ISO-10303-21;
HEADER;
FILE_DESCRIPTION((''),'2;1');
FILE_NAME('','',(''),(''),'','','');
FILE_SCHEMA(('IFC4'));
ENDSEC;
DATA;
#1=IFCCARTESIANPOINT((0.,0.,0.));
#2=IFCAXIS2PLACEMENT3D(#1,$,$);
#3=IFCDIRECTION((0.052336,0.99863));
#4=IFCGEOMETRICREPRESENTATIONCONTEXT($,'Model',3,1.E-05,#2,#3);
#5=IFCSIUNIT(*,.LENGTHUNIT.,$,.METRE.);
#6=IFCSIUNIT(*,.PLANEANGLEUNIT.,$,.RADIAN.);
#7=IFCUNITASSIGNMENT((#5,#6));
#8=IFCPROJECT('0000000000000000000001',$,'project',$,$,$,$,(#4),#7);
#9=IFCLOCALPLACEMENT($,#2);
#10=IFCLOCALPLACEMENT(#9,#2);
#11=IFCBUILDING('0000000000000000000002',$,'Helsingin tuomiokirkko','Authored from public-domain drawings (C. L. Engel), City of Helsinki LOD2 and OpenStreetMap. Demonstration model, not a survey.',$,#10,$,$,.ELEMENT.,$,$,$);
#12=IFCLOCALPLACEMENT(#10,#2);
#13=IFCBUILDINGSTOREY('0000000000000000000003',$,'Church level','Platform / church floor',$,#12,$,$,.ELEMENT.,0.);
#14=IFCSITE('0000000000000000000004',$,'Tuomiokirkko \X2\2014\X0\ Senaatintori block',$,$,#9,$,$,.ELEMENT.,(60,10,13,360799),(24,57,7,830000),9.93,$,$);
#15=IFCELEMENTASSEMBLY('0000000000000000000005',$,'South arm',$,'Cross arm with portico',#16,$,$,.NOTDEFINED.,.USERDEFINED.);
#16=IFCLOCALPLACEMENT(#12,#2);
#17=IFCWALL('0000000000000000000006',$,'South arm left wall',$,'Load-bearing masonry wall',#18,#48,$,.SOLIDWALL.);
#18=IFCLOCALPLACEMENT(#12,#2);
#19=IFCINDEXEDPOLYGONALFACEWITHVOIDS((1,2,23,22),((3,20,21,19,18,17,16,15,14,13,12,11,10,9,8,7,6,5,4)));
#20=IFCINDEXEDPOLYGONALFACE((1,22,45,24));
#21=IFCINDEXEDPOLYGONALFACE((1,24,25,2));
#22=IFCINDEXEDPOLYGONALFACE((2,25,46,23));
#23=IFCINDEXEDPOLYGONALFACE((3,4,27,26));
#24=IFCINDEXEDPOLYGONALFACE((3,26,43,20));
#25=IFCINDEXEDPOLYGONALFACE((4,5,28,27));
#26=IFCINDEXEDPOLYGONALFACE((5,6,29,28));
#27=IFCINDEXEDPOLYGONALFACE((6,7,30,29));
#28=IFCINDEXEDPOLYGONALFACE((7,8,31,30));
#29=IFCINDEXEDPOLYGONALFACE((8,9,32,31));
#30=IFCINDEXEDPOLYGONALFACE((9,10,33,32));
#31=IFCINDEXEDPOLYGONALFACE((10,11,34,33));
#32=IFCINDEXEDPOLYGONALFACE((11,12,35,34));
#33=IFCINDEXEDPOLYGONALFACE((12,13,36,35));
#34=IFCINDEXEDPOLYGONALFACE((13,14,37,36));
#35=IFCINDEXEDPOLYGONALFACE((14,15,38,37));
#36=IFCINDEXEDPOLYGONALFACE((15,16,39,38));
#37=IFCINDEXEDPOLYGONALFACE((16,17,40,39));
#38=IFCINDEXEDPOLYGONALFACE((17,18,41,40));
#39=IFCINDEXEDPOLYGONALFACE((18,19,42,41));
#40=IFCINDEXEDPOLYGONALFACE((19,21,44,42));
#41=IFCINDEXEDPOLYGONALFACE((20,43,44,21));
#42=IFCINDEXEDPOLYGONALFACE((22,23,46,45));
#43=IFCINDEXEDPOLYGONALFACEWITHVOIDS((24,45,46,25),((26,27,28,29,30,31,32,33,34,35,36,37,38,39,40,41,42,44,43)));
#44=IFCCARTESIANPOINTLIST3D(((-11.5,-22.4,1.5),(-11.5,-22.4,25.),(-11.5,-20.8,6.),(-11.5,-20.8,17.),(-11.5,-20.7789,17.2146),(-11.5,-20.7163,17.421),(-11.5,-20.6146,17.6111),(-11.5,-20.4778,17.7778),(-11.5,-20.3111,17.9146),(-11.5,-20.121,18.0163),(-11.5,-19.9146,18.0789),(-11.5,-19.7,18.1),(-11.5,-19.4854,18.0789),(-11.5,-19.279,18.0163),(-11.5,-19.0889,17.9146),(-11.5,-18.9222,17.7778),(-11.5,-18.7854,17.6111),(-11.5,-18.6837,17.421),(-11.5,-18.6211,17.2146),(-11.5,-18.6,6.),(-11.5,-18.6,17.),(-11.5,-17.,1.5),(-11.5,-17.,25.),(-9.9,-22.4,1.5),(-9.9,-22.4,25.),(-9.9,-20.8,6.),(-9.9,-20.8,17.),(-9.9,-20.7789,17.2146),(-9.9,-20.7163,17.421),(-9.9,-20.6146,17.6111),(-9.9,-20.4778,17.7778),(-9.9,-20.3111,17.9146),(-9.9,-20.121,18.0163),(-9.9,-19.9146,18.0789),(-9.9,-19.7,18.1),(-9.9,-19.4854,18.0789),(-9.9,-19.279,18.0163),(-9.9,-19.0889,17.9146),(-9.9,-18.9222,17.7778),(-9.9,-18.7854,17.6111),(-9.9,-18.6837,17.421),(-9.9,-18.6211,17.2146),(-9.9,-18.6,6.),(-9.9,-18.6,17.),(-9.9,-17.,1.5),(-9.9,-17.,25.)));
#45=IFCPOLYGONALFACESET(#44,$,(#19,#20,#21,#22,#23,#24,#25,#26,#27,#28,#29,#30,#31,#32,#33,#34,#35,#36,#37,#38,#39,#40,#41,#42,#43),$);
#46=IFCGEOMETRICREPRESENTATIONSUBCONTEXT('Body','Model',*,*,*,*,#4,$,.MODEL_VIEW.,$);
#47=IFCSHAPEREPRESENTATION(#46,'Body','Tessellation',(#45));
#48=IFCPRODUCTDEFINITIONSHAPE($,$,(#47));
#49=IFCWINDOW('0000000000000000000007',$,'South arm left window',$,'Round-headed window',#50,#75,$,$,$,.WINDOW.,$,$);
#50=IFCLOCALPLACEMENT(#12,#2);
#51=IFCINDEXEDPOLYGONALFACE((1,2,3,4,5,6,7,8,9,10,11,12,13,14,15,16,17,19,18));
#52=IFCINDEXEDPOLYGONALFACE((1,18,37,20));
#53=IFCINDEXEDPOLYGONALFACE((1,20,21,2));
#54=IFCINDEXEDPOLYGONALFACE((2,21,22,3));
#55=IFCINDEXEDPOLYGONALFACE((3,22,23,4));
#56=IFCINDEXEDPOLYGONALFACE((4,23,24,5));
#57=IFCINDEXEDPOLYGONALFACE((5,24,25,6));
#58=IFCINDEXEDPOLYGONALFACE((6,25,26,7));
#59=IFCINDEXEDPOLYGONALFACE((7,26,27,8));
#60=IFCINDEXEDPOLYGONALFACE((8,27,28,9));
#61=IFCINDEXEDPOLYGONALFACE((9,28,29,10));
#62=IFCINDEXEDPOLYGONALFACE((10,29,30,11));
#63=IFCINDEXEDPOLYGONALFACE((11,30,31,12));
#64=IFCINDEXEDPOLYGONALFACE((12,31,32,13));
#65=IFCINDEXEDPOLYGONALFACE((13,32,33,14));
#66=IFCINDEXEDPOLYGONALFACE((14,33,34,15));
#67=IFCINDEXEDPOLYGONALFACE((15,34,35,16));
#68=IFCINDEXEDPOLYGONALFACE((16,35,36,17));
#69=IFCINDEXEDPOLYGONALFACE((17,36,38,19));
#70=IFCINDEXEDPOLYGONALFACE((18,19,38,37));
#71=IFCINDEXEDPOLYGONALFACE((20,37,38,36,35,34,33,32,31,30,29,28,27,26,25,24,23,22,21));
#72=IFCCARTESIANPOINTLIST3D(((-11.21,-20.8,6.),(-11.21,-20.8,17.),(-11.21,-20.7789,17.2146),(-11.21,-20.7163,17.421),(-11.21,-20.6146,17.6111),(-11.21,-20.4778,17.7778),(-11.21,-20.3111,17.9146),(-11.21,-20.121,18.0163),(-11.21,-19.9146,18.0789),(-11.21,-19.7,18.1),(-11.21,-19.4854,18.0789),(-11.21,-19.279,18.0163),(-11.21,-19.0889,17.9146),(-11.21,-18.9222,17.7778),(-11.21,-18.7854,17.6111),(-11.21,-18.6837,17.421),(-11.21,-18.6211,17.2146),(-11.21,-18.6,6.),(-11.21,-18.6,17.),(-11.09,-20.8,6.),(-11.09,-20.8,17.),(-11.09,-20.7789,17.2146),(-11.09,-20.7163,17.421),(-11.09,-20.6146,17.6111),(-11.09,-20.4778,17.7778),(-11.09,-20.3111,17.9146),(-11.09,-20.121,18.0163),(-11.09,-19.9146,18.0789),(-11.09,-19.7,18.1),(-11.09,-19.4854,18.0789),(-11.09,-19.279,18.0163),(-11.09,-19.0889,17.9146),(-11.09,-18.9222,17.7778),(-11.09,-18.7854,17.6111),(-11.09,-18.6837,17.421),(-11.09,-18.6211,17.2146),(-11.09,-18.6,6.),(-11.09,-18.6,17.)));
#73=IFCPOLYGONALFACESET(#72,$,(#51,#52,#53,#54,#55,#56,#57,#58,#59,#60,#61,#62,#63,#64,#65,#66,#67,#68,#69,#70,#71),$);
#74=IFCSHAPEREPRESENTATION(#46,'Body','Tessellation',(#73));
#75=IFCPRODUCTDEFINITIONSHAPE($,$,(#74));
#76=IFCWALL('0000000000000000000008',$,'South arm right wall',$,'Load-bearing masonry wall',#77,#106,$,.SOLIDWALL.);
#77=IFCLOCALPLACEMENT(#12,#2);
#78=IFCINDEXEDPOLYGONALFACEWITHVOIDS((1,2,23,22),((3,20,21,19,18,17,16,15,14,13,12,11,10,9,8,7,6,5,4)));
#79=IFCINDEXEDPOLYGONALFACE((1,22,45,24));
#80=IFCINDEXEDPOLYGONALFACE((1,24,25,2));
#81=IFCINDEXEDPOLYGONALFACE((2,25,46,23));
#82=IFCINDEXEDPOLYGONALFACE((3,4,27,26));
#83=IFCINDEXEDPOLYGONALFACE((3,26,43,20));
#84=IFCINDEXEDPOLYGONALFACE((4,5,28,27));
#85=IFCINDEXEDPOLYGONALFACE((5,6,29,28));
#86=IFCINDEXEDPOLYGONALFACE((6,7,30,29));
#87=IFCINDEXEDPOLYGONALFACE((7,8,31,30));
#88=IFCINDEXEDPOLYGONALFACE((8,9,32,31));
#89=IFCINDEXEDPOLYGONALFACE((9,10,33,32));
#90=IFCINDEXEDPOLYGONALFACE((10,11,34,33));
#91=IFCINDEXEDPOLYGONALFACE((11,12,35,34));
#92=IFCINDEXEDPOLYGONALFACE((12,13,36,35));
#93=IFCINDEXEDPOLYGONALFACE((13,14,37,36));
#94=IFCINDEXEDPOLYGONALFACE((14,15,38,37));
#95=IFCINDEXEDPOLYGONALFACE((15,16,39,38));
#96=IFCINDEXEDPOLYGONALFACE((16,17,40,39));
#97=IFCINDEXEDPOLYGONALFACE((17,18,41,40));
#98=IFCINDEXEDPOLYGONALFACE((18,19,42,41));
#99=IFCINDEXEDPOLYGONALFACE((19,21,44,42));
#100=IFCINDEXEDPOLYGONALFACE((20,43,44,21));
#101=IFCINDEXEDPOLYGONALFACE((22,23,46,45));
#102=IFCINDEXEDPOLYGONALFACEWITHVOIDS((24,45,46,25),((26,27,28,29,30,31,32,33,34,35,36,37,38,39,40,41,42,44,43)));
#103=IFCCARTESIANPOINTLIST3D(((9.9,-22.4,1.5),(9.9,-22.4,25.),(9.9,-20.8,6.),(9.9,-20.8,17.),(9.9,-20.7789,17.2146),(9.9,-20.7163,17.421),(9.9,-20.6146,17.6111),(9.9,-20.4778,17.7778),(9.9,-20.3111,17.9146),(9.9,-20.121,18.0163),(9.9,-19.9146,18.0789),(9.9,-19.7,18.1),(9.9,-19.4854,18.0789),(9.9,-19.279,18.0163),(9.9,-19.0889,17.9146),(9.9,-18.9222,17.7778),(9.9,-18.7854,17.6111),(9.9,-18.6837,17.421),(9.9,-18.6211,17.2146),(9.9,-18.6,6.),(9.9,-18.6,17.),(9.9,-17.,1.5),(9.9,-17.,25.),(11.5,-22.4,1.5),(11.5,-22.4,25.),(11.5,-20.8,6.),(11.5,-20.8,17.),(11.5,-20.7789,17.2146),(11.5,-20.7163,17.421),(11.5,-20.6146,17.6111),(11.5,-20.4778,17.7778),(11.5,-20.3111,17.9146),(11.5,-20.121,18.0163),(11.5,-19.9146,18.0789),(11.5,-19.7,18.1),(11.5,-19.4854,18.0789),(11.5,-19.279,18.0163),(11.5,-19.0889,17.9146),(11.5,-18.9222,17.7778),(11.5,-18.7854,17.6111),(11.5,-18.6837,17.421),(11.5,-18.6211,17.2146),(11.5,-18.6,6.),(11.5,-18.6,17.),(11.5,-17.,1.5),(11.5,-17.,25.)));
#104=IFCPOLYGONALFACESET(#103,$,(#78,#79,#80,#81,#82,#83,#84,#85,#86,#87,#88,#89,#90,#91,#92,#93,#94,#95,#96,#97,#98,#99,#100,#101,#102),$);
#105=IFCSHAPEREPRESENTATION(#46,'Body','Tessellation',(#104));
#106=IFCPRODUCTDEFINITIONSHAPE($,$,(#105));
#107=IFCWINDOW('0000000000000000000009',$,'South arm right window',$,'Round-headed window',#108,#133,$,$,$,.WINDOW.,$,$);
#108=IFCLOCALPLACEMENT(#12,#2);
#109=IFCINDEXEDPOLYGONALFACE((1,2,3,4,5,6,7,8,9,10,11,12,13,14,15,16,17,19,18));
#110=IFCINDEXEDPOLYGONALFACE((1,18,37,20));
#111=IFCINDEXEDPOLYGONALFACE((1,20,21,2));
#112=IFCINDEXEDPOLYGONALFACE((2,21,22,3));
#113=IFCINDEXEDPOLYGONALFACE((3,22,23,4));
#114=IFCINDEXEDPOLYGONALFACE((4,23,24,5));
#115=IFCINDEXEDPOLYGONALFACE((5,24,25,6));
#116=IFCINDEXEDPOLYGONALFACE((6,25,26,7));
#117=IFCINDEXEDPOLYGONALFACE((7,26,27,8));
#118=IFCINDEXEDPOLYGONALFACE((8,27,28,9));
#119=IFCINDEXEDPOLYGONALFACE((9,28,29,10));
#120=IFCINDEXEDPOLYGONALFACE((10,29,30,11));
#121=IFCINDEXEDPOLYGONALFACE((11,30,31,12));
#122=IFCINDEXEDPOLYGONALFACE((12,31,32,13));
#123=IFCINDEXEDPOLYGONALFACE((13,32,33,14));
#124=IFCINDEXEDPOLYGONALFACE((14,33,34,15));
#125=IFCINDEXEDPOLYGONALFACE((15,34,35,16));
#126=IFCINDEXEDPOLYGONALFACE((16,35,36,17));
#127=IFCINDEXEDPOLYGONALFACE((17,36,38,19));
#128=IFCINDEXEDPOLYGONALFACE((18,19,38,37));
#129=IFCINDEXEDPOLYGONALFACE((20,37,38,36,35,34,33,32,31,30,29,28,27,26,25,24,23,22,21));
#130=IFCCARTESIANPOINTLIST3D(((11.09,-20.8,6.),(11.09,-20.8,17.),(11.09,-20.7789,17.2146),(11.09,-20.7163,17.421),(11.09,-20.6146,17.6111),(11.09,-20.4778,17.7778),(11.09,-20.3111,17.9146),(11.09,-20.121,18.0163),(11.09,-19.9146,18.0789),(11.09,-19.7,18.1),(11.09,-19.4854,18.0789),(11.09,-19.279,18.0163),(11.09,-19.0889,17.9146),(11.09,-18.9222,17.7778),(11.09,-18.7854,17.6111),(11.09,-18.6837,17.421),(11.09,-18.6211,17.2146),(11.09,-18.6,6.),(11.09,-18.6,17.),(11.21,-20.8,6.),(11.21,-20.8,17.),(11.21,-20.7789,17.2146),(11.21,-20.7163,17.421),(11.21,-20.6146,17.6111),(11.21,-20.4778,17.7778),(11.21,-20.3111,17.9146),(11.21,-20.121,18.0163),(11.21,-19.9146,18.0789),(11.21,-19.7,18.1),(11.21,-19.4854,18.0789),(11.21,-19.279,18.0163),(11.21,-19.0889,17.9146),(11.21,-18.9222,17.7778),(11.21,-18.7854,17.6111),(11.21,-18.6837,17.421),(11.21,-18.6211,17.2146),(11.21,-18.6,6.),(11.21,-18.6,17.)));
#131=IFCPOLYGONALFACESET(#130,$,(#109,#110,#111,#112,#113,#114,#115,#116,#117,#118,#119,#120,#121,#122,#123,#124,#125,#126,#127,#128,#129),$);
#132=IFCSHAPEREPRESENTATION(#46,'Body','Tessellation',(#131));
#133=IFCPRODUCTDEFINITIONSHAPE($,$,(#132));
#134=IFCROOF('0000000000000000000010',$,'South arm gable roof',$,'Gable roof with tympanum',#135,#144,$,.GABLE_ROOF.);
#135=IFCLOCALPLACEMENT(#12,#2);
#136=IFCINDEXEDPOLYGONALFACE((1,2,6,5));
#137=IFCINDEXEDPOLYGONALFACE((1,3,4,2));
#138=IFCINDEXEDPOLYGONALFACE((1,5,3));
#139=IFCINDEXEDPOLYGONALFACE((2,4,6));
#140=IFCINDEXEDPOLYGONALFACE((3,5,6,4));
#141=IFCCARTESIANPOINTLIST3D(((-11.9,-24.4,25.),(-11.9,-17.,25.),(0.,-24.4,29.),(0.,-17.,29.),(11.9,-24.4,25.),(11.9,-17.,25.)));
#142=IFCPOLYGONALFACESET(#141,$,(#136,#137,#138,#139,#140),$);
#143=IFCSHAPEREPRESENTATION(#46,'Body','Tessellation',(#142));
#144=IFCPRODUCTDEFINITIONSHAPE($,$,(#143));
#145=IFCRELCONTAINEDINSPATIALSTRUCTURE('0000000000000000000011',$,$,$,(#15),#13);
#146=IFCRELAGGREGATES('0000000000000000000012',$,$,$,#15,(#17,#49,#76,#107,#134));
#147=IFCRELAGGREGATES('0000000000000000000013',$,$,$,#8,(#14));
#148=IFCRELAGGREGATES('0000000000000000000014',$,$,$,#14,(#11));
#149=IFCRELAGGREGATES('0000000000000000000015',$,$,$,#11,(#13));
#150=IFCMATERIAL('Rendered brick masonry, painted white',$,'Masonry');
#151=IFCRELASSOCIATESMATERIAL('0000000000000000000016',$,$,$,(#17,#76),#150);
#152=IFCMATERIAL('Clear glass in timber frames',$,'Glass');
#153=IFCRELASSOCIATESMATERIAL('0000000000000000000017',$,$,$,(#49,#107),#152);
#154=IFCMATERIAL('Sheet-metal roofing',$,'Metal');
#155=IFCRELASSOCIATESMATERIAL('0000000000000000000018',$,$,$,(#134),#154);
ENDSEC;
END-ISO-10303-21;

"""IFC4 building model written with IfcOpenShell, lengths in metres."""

from ifc_helpers import new_model, si_unit, direction, frame, frame_2d, origin, place, context, subcontext, project, spatial, polyline, rectangle, outline, extrude, material, element, fill, aggregate, save


model = new_model("IFC4")

# Units and contexts
model_context = context("Model", 3, precision=1e-05, world=origin(), true_north=direction((0.052336, 0.99863)))
body_context = subcontext(model_context, "Body", "Model", "MODEL_VIEW")
ifc_project = project(units=[si_unit("LENGTHUNIT", "METRE"), si_unit("PLANEANGLEUNIT", "RADIAN")], contexts=[model_context])

# Site, building, storey
site_placement = place(None, origin())
site = spatial("IfcSite", under=ifc_project, at=site_placement, Name="Tuomiokirkko — Senaatintori block", CompositionType="ELEMENT", RefLatitude=(60, 10, 13, 360799), RefLongitude=(24, 57, 7, 830000), RefElevation=9.93)
building_placement = place(site_placement, origin())
building = spatial("IfcBuilding", under=site, at=building_placement, Name="Helsingin tuomiokirkko", Description="Authored from public-domain drawings (C. L. Engel), City of Helsinki LOD2 and OpenStreetMap. Demonstration model, not a survey.", CompositionType="ELEMENT")
storey_placement = place(building_placement, origin())
storey = spatial("IfcBuildingStorey", under=building, at=storey_placement, Name="Church level", Description="Platform / church floor", CompositionType="ELEMENT", Elevation=0.0)

# Element assembly, walls, openings, windows, roof
assembly_1_placement = place(building_placement, origin())
assembly_1 = element("IfcElementAssembly", 1, at=assembly_1_placement, inside=storey, Name="South arm", ObjectType="Cross arm with portico", AssemblyPlace="NOTDEFINED", PredefinedType="USERDEFINED")
ifc_material_1 = material(Name="Rendered brick masonry, painted white", Category="Masonry")
ifc_material_2 = material(Name="Clear glass in timber frames", Category="Glass")
wall_1_placement = place(building_placement, origin())
wall_1 = element("IfcWall", 2, at=wall_1_placement, material=ifc_material_1, Name="South arm left wall", ObjectType="Load-bearing masonry wall", PredefinedType="SOLIDWALL", context=body_context, shape_type="SweptSolid", body=[
    extrude(rectangle(XDim=5.4, YDim=1.6, at=frame_2d((0.0, 0.0), x_axis=(0.0, -1.0))), frame((-10.7, -19.7, 1.5)), (0.0, 0.0, 1.0), 23.5),
])
opening_1_placement = place(building_placement, origin())
opening_1 = element("IfcOpeningElement", 3, at=opening_1_placement, cuts=wall_1, PredefinedType="OPENING", context=body_context, shape_type="SweptSolid", body=[
    extrude(outline(polyline([(-1.1, 0.0), (1.1, 0.0), (1.1, 11.0), (1.0789, 11.2146), (1.0163, 11.421), (0.9146, 11.6111), (0.7778, 11.7778), (0.6111, 11.9146), (0.421, 12.0163), (0.2146, 12.0789), (0.0, 12.1), (-0.2146, 12.0789), (-0.421, 12.0163), (-0.6111, 11.9146), (-0.7778, 11.7778), (-0.9146, 11.6111), (-1.0163, 11.421), (-1.0789, 11.2146), (-1.1, 11.0), (-1.1, 0.0)])), frame((-9.7, -19.7, 6.0), z_axis=(-1.0, 0.0, 0.0), x_axis=(0.0, -1.0, 0.0)), (0.0, 0.0, 1.0), 2.0),
])
window_1_placement = place(building_placement, origin())
window_1 = element("IfcWindow", 4, at=window_1_placement, material=ifc_material_2, Name="South arm left window", ObjectType="Round-headed window", PredefinedType="WINDOW", context=body_context, shape_type="SweptSolid", body=[
    extrude(outline(polyline([(-1.1, 0.0), (1.1, 0.0), (1.1, 11.0), (1.0789, 11.2146), (1.0163, 11.421), (0.9146, 11.6111), (0.7778, 11.7778), (0.6111, 11.9146), (0.421, 12.0163), (0.2146, 12.0789), (0.0, 12.1), (-0.2146, 12.0789), (-0.421, 12.0163), (-0.6111, 11.9146), (-0.7778, 11.7778), (-0.9146, 11.6111), (-1.0163, 11.421), (-1.0789, 11.2146), (-1.1, 11.0), (-1.1, 0.0)])), frame((-11.09, -19.7, 6.0), z_axis=(-1.0, 0.0, 0.0), x_axis=(0.0, -1.0, 0.0)), (0.0, 0.0, 1.0), 0.12),
])
fill(opening_1, window_1)
wall_2_placement = place(building_placement, origin())
wall_2 = element("IfcWall", 5, at=wall_2_placement, material=ifc_material_1, Name="South arm right wall", ObjectType="Load-bearing masonry wall", PredefinedType="SOLIDWALL", context=body_context, shape_type="SweptSolid", body=[
    extrude(rectangle(XDim=5.4, YDim=1.6, at=frame_2d((0.0, 0.0), x_axis=(0.0, -1.0))), frame((10.7, -19.7, 1.5)), (0.0, 0.0, 1.0), 23.5),
])
opening_2_placement = place(building_placement, origin())
opening_2 = element("IfcOpeningElement", 6, at=opening_2_placement, cuts=wall_2, PredefinedType="OPENING", context=body_context, shape_type="SweptSolid", body=[
    extrude(outline(polyline([(-1.1, 0.0), (1.1, 0.0), (1.1, 11.0), (1.0789, 11.2146), (1.0163, 11.421), (0.9146, 11.6111), (0.7778, 11.7778), (0.6111, 11.9146), (0.421, 12.0163), (0.2146, 12.0789), (0.0, 12.1), (-0.2146, 12.0789), (-0.421, 12.0163), (-0.6111, 11.9146), (-0.7778, 11.7778), (-0.9146, 11.6111), (-1.0163, 11.421), (-1.0789, 11.2146), (-1.1, 11.0), (-1.1, 0.0)])), frame((11.7, -19.7, 6.0), z_axis=(-1.0, 0.0, 0.0), x_axis=(0.0, -1.0, 0.0)), (0.0, 0.0, 1.0), 2.0),
])
window_2_placement = place(building_placement, origin())
window_2 = element("IfcWindow", 7, at=window_2_placement, material=ifc_material_2, Name="South arm right window", ObjectType="Round-headed window", PredefinedType="WINDOW", context=body_context, shape_type="SweptSolid", body=[
    extrude(outline(polyline([(-1.1, 0.0), (1.1, 0.0), (1.1, 11.0), (1.0789, 11.2146), (1.0163, 11.421), (0.9146, 11.6111), (0.7778, 11.7778), (0.6111, 11.9146), (0.421, 12.0163), (0.2146, 12.0789), (0.0, 12.1), (-0.2146, 12.0789), (-0.421, 12.0163), (-0.6111, 11.9146), (-0.7778, 11.7778), (-0.9146, 11.6111), (-1.0163, 11.421), (-1.0789, 11.2146), (-1.1, 11.0), (-1.1, 0.0)])), frame((11.21, -19.7, 6.0), z_axis=(-1.0, 0.0, 0.0), x_axis=(0.0, -1.0, 0.0)), (0.0, 0.0, 1.0), 0.12),
])
fill(opening_2, window_2)
ifc_material_3 = material(Name="Sheet-metal roofing", Category="Metal")
roof_placement = place(building_placement, origin())
roof = element("IfcRoof", 8, at=roof_placement, material=ifc_material_3, Name="South arm gable roof", ObjectType="Gable roof with tympanum", PredefinedType="GABLE_ROOF", context=body_context, shape_type="SweptSolid", body=[
    extrude(outline(polyline([(-11.9, 0.0), (11.9, 0.0), (0.0, 4.0), (-11.9, 0.0)])), frame((0.0, -17.0, 25.0), z_axis=(0.0, -1.0, 0.0), x_axis=(1.0, 0.0, 0.0)), (0.0, 0.0, 1.0), 7.4),
])
aggregate(assembly_1, [wall_1, window_1, wall_2, window_2, roof])

save(model, "model.ifc")
